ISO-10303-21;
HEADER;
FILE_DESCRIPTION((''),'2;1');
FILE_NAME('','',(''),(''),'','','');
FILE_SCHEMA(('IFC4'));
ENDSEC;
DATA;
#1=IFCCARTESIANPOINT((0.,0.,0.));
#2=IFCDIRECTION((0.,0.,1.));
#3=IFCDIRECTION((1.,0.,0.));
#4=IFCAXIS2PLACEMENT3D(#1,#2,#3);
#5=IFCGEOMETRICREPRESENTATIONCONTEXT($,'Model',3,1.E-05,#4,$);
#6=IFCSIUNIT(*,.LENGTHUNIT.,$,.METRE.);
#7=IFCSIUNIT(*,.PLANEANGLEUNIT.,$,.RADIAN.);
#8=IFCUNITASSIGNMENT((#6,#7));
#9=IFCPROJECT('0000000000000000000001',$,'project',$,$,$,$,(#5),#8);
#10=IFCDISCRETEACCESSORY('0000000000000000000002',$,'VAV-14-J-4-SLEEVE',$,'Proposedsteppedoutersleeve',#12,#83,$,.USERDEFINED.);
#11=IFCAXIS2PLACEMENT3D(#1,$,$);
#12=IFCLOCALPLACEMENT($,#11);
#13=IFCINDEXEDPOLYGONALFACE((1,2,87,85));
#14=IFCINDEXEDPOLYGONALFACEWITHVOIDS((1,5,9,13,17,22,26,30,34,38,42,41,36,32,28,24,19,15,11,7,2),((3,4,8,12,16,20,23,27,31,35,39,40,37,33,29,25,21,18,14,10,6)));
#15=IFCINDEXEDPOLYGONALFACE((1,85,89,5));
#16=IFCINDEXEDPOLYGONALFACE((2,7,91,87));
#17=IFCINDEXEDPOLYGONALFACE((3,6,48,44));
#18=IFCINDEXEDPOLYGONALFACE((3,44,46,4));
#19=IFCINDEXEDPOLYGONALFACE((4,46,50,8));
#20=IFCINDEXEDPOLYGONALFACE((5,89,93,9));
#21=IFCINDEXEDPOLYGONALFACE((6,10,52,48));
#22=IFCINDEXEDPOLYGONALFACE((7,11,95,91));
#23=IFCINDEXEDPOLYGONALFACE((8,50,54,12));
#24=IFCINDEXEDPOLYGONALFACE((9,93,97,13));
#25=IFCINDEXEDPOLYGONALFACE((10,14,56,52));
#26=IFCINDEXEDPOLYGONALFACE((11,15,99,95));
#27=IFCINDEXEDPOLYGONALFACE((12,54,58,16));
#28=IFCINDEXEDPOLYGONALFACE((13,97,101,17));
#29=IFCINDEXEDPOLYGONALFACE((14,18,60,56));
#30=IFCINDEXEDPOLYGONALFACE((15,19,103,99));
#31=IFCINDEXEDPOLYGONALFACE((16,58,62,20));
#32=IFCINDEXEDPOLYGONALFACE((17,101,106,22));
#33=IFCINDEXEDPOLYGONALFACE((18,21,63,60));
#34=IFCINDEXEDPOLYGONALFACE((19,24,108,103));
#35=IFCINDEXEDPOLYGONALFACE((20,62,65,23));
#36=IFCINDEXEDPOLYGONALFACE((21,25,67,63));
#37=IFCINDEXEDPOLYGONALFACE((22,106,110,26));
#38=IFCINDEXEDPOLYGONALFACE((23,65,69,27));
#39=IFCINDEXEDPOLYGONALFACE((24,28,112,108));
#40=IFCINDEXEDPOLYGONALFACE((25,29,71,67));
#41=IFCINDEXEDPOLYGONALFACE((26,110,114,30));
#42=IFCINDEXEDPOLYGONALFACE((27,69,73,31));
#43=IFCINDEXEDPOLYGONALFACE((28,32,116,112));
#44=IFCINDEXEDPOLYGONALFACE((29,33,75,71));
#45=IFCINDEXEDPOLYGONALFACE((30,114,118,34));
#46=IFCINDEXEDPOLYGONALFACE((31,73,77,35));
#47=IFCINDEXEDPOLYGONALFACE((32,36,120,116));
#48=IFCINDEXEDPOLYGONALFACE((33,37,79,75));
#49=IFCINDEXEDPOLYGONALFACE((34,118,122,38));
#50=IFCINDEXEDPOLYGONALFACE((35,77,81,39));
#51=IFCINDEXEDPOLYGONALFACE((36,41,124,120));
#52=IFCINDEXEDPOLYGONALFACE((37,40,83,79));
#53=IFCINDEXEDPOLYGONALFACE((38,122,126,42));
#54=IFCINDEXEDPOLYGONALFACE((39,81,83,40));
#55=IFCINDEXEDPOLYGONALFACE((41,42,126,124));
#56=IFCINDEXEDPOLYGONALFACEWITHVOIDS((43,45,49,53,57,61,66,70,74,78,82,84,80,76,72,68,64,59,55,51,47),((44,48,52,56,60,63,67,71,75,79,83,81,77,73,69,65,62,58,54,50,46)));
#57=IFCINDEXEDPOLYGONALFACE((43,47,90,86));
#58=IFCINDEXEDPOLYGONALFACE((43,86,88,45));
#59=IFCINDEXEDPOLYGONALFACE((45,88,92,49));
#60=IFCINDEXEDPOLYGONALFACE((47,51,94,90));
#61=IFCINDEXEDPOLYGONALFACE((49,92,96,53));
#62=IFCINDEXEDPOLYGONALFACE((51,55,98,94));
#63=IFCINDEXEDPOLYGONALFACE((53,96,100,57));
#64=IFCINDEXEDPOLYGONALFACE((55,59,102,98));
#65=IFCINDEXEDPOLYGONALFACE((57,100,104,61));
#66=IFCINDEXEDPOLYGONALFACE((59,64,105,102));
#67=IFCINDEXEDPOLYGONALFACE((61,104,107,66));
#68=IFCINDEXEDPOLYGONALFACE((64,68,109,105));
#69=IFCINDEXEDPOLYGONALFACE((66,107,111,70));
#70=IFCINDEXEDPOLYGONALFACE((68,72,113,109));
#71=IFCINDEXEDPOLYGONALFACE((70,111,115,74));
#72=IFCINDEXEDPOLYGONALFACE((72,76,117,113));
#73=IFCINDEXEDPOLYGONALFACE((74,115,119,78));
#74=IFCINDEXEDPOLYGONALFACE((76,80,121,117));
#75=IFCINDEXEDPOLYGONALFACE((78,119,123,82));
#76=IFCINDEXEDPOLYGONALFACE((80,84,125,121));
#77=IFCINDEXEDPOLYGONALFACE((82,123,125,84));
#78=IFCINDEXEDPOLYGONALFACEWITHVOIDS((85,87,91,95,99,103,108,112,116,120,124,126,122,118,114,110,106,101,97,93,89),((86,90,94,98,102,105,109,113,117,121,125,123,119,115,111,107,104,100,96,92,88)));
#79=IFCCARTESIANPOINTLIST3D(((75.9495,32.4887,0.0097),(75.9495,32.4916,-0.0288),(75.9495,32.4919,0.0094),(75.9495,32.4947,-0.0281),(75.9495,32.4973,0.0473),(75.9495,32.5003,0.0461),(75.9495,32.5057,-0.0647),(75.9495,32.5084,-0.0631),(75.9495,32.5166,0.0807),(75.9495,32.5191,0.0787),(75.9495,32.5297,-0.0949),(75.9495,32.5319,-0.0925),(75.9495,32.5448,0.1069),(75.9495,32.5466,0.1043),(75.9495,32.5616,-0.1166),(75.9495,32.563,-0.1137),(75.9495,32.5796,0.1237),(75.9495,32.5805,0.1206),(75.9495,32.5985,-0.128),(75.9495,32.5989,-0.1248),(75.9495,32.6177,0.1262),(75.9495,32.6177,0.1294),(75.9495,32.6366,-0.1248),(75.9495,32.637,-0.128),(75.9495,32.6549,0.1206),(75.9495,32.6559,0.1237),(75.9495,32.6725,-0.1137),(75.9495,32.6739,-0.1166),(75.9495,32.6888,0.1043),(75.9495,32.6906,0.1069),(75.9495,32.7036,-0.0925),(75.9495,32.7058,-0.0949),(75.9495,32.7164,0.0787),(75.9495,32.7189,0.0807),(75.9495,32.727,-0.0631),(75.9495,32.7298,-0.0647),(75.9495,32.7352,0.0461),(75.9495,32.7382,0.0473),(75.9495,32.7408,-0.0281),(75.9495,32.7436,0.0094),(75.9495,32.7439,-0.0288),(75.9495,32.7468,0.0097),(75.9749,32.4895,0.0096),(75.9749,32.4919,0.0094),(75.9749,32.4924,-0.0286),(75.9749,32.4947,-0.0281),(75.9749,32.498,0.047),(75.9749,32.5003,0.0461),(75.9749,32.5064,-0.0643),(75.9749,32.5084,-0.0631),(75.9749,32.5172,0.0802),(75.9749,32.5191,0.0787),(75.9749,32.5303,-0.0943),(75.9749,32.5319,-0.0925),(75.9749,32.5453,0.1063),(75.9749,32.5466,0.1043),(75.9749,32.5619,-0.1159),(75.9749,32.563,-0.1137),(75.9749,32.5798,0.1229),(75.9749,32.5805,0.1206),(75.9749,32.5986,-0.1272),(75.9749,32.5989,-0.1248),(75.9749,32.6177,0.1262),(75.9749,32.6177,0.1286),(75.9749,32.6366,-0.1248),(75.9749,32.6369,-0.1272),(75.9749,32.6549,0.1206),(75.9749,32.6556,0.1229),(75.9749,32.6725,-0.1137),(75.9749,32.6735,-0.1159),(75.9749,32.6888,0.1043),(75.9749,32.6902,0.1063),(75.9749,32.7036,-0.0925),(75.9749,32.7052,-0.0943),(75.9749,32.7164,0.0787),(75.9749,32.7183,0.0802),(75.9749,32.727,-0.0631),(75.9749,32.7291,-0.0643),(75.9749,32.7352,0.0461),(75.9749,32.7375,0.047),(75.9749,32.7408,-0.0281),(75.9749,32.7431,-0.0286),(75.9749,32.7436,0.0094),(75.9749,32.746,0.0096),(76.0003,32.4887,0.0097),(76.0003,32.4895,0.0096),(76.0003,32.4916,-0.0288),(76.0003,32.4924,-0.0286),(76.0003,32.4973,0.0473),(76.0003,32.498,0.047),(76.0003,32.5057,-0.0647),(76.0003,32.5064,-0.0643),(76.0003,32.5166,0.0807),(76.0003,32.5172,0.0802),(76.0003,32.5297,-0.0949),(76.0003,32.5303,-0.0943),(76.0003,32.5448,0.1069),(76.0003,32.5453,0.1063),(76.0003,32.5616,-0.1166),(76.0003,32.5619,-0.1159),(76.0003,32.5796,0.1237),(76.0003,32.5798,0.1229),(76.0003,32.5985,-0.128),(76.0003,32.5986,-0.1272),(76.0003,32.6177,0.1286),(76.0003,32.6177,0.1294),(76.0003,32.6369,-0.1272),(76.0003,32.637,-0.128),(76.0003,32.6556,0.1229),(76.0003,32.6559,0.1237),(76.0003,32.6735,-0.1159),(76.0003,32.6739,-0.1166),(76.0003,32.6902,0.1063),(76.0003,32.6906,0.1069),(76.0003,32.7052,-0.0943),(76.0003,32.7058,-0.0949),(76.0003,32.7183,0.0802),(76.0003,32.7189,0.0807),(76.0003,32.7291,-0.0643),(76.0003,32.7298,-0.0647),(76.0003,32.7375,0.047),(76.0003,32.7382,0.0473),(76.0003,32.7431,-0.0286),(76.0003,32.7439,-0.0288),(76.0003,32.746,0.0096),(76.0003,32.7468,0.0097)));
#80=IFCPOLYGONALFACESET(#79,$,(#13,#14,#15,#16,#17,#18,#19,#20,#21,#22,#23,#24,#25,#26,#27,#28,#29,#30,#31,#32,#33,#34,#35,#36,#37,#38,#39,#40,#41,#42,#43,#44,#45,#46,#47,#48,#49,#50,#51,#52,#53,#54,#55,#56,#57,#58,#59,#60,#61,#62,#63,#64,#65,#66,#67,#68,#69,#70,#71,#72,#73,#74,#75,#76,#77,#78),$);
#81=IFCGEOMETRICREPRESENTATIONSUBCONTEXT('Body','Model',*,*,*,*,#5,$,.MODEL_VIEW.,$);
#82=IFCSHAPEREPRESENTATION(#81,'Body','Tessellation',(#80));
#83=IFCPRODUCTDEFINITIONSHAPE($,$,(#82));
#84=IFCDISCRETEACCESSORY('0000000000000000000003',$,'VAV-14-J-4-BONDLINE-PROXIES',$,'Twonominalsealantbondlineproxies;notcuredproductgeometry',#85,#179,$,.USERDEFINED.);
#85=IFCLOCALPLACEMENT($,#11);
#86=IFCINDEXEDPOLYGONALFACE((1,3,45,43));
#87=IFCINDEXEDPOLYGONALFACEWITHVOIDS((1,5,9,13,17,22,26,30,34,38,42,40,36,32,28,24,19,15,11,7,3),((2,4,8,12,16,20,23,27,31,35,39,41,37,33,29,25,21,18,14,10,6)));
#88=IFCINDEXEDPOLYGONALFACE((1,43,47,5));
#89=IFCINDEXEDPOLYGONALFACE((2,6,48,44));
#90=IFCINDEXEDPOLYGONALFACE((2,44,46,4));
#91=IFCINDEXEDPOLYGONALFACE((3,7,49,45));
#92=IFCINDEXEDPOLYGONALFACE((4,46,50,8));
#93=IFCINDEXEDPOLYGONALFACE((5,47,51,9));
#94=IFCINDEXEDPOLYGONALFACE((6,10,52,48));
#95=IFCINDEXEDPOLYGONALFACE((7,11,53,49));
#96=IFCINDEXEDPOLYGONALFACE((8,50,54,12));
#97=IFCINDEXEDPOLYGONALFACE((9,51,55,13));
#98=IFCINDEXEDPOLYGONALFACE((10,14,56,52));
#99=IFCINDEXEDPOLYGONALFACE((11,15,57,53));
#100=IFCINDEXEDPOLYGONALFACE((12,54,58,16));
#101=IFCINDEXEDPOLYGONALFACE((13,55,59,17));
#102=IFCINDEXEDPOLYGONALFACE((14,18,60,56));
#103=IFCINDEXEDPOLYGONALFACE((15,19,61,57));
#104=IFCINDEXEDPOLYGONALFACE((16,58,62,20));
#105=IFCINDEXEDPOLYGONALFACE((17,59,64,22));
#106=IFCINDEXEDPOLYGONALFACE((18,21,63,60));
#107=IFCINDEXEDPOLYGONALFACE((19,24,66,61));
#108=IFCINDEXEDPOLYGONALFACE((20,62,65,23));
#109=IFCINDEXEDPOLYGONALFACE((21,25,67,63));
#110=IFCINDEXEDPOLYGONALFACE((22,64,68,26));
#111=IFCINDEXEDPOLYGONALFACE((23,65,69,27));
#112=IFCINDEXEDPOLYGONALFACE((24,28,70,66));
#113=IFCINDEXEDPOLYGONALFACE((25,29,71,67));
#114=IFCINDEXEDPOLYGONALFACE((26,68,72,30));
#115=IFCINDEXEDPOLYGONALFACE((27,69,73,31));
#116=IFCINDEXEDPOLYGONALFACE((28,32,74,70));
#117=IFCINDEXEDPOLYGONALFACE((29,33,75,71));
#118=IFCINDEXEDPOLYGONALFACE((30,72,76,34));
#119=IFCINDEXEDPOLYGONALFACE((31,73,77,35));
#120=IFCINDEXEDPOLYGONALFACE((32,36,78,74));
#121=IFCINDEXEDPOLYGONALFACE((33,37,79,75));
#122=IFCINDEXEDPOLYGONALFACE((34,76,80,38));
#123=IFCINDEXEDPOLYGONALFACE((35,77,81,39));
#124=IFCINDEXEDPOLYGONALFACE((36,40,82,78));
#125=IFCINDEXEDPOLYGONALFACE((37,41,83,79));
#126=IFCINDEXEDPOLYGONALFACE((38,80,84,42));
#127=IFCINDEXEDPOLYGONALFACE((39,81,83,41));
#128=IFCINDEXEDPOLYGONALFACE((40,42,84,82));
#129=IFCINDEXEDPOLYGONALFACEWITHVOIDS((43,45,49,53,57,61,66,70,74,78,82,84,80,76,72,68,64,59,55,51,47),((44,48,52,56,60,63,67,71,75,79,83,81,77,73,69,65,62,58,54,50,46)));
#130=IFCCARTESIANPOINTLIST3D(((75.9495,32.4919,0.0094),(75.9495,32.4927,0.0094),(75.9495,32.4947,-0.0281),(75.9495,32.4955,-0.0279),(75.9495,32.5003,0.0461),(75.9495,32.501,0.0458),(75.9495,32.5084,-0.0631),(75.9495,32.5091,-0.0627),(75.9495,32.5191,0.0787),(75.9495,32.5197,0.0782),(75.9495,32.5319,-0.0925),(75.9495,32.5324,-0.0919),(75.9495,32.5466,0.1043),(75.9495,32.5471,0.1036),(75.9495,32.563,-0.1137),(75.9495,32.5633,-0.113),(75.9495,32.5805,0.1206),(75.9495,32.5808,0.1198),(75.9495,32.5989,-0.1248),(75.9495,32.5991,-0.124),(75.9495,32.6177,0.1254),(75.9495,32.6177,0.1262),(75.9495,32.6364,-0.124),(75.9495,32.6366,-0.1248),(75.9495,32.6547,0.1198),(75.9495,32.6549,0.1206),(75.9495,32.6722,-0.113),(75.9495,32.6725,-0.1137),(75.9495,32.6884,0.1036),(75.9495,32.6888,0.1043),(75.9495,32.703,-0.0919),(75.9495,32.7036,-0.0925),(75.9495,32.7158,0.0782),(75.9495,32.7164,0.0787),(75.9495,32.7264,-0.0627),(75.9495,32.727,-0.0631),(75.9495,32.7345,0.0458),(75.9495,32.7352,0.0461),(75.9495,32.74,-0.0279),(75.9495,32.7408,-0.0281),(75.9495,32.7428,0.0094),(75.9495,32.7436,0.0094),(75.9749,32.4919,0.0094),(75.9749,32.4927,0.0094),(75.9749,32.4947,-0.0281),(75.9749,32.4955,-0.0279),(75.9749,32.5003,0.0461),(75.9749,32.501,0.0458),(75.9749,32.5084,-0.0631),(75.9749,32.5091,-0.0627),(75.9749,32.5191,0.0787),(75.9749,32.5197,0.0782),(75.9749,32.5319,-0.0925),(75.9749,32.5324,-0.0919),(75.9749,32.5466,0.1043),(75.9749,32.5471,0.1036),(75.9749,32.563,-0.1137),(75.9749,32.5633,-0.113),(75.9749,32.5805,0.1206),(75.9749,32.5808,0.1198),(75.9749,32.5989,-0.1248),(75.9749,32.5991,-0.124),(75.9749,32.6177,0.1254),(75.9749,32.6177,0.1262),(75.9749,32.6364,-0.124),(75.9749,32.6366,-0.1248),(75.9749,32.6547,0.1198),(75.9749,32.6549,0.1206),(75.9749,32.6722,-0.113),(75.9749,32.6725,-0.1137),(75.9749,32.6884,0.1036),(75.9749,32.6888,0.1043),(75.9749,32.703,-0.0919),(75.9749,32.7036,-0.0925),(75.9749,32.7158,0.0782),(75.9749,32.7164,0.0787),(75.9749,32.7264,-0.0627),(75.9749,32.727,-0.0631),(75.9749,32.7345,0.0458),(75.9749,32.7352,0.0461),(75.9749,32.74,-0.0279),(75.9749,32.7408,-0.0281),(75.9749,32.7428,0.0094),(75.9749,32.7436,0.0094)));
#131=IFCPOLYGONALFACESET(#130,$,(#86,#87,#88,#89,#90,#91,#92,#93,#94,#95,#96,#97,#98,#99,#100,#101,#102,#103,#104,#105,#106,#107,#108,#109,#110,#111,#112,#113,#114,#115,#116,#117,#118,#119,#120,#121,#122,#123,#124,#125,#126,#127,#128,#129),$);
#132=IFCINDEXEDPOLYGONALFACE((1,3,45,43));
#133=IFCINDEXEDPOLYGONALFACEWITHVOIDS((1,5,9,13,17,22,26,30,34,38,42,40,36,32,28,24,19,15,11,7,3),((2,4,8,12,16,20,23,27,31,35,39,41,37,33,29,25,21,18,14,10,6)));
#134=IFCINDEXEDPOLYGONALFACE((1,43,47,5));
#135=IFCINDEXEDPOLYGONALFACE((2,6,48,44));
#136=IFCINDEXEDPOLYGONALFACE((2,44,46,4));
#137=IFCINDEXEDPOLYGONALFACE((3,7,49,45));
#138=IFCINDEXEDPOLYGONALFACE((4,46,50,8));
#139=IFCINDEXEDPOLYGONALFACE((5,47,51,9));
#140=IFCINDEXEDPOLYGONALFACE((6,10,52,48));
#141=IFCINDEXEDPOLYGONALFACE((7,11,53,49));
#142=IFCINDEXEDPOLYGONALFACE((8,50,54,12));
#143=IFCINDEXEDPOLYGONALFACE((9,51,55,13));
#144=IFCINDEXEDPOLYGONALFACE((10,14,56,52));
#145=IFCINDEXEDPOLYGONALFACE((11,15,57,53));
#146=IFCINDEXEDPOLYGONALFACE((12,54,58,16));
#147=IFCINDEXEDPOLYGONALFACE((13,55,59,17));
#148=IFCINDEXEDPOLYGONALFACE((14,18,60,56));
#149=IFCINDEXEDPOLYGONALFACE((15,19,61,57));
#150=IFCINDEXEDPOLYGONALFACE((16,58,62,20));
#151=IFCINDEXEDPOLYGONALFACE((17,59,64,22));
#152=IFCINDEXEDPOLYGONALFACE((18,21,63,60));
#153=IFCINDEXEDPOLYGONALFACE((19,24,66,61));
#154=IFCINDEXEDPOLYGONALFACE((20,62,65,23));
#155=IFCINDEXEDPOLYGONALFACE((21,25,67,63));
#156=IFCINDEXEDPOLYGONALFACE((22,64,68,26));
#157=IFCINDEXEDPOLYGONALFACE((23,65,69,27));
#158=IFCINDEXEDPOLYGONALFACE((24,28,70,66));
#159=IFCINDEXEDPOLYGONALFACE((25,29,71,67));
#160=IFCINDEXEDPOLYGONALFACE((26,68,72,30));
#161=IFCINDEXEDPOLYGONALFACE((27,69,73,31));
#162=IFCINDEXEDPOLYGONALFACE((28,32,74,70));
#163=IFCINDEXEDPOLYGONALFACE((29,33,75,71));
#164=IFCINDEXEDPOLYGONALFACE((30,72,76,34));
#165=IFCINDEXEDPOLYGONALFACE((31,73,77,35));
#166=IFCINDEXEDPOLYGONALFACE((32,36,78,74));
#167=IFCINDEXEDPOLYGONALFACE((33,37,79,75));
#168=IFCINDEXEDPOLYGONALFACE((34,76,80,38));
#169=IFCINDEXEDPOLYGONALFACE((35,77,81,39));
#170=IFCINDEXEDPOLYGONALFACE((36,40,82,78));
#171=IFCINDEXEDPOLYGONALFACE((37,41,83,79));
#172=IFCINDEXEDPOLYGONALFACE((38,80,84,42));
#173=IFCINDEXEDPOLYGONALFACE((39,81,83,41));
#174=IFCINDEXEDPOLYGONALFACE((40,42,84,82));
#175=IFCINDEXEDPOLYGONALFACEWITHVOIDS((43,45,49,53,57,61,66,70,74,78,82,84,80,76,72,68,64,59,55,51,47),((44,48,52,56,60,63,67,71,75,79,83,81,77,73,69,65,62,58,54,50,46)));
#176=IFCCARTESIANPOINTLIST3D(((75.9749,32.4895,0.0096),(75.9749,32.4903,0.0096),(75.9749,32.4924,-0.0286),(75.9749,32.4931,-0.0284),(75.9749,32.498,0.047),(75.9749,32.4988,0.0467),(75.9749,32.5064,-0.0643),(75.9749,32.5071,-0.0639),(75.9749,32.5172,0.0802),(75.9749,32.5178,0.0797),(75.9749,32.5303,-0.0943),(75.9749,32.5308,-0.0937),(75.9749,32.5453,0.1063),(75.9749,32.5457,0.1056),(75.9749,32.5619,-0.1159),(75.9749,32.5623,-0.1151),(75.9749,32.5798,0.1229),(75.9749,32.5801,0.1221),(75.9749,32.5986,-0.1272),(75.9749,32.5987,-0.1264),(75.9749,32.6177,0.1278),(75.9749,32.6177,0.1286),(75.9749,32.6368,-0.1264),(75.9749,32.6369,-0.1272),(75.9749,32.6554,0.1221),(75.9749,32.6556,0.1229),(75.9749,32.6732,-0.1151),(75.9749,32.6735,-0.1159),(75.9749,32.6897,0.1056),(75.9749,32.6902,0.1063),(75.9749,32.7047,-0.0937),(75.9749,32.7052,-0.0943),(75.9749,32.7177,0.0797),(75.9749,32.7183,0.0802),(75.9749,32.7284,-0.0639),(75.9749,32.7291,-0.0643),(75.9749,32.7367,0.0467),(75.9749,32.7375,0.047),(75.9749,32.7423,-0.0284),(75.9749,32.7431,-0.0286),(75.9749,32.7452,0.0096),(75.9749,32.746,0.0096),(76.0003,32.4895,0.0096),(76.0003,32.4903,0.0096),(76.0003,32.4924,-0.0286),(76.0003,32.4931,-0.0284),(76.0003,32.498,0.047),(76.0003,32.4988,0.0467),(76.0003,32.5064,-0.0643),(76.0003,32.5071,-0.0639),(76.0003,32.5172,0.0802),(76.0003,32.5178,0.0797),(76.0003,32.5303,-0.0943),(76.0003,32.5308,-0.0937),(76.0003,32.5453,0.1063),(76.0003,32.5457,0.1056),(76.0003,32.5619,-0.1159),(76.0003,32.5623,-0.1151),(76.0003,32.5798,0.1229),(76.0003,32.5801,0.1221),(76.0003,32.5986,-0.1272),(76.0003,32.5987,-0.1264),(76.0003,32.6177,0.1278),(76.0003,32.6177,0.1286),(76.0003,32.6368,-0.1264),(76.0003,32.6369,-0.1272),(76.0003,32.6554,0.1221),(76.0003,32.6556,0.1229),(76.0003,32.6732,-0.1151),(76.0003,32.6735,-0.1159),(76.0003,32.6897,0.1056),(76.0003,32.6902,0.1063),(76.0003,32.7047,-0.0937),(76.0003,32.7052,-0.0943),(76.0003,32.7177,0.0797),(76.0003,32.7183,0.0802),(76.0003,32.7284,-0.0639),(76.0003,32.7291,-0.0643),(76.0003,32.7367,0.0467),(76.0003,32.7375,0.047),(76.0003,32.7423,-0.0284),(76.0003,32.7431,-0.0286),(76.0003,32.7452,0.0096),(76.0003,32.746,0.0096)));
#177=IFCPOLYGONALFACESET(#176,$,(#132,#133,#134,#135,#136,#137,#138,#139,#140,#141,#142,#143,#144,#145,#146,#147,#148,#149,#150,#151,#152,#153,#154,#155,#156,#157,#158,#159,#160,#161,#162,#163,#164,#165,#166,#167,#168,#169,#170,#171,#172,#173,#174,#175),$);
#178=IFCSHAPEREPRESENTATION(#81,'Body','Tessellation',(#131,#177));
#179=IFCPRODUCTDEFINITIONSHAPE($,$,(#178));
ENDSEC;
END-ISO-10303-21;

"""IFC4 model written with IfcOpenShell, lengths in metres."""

from ifc_helpers import new_model, entity, si_unit, frame, origin_with_axes, place, context, subcontext, project, element, save


model = new_model("IFC4")

# Units and contexts
model_context = context("Model", 3, precision=1e-05, world=origin_with_axes())
body_context = subcontext(model_context, "Body", "Model", "MODEL_VIEW")
ifc_project = project(units=[si_unit("LENGTHUNIT", "METRE"), si_unit("PLANEANGLEUNIT", "RADIAN")], contexts=[model_context])

# Discrete accessories
discrete_accessory_1_placement = place(None, frame((75.9749, 32.6177, 0.0), z_axis=(0.0, 1.0, 0.0), x_axis=(0.0, 0.0, 1.0)))
element("IfcDiscreteAccessory", 1, at=discrete_accessory_1_placement, Name="VAV-14-J-4-SLEEVE", ObjectType="Proposedsteppedoutersleeve", PredefinedType="USERDEFINED", context=body_context, shape_type="SweptSolid", body=[
    entity("IfcRevolvedAreaSolid", entity("IfcArbitraryClosedProfileDef", "AREA", None, entity("IfcPolyline", [entity("IfcCartesianPoint", [0.1262, -0.0254]), entity("IfcCartesianPoint", [0.1294, -0.0254]), entity("IfcCartesianPoint", [0.1294, 0.0254]), entity("IfcCartesianPoint", [0.1286, 0.0254]), entity("IfcCartesianPoint", [0.1286, 0.0]), entity("IfcCartesianPoint", [0.1262, 0.0]), entity("IfcCartesianPoint", [0.1262, -0.0254])])), entity("IfcAxis2Placement3D", entity("IfcCartesianPoint", [0.0, 0.0, 0.0])), entity("IfcAxis1Placement", entity("IfcCartesianPoint", [0.0, 0.0, 0.0]), entity("IfcDirection", [0.0, 1.0, 0.0])), 6.283185),
])
discrete_accessory_2_placement = place(None, frame((75.9749, 32.6177, 0.0), z_axis=(0.0, 1.0, 0.0), x_axis=(0.0, 0.0, 1.0)))
element("IfcDiscreteAccessory", 2, at=discrete_accessory_2_placement, Name="VAV-14-J-4-BONDLINE-PROXIES", ObjectType="Twonominalsealantbondlineproxies;notcuredproductgeometry", PredefinedType="USERDEFINED", context=body_context, shape_type="SweptSolid", body=[
    entity("IfcRevolvedAreaSolid", entity("IfcArbitraryClosedProfileDef", "AREA", None, entity("IfcPolyline", [entity("IfcCartesianPoint", [0.1254, -0.0254]), entity("IfcCartesianPoint", [0.1262, -0.0254]), entity("IfcCartesianPoint", [0.1262, 0.0]), entity("IfcCartesianPoint", [0.1254, 0.0]), entity("IfcCartesianPoint", [0.1254, -0.0254])])), entity("IfcAxis2Placement3D", entity("IfcCartesianPoint", [0.0, 0.0, 0.0])), entity("IfcAxis1Placement", entity("IfcCartesianPoint", [0.0, 0.0, 0.0]), entity("IfcDirection", [0.0, 1.0, 0.0])), 6.283185),
    entity("IfcRevolvedAreaSolid", entity("IfcArbitraryClosedProfileDef", "AREA", None, entity("IfcPolyline", [entity("IfcCartesianPoint", [0.1278, 0.0]), entity("IfcCartesianPoint", [0.1286, 0.0]), entity("IfcCartesianPoint", [0.1286, 0.0254]), entity("IfcCartesianPoint", [0.1278, 0.0254]), entity("IfcCartesianPoint", [0.1278, 0.0])])), entity("IfcAxis2Placement3D", entity("IfcCartesianPoint", [0.0, 0.0, 0.0])), entity("IfcAxis1Placement", entity("IfcCartesianPoint", [0.0, 0.0, 0.0]), entity("IfcDirection", [0.0, 1.0, 0.0])), 6.283185),
])

save(model, "model.ifc")
